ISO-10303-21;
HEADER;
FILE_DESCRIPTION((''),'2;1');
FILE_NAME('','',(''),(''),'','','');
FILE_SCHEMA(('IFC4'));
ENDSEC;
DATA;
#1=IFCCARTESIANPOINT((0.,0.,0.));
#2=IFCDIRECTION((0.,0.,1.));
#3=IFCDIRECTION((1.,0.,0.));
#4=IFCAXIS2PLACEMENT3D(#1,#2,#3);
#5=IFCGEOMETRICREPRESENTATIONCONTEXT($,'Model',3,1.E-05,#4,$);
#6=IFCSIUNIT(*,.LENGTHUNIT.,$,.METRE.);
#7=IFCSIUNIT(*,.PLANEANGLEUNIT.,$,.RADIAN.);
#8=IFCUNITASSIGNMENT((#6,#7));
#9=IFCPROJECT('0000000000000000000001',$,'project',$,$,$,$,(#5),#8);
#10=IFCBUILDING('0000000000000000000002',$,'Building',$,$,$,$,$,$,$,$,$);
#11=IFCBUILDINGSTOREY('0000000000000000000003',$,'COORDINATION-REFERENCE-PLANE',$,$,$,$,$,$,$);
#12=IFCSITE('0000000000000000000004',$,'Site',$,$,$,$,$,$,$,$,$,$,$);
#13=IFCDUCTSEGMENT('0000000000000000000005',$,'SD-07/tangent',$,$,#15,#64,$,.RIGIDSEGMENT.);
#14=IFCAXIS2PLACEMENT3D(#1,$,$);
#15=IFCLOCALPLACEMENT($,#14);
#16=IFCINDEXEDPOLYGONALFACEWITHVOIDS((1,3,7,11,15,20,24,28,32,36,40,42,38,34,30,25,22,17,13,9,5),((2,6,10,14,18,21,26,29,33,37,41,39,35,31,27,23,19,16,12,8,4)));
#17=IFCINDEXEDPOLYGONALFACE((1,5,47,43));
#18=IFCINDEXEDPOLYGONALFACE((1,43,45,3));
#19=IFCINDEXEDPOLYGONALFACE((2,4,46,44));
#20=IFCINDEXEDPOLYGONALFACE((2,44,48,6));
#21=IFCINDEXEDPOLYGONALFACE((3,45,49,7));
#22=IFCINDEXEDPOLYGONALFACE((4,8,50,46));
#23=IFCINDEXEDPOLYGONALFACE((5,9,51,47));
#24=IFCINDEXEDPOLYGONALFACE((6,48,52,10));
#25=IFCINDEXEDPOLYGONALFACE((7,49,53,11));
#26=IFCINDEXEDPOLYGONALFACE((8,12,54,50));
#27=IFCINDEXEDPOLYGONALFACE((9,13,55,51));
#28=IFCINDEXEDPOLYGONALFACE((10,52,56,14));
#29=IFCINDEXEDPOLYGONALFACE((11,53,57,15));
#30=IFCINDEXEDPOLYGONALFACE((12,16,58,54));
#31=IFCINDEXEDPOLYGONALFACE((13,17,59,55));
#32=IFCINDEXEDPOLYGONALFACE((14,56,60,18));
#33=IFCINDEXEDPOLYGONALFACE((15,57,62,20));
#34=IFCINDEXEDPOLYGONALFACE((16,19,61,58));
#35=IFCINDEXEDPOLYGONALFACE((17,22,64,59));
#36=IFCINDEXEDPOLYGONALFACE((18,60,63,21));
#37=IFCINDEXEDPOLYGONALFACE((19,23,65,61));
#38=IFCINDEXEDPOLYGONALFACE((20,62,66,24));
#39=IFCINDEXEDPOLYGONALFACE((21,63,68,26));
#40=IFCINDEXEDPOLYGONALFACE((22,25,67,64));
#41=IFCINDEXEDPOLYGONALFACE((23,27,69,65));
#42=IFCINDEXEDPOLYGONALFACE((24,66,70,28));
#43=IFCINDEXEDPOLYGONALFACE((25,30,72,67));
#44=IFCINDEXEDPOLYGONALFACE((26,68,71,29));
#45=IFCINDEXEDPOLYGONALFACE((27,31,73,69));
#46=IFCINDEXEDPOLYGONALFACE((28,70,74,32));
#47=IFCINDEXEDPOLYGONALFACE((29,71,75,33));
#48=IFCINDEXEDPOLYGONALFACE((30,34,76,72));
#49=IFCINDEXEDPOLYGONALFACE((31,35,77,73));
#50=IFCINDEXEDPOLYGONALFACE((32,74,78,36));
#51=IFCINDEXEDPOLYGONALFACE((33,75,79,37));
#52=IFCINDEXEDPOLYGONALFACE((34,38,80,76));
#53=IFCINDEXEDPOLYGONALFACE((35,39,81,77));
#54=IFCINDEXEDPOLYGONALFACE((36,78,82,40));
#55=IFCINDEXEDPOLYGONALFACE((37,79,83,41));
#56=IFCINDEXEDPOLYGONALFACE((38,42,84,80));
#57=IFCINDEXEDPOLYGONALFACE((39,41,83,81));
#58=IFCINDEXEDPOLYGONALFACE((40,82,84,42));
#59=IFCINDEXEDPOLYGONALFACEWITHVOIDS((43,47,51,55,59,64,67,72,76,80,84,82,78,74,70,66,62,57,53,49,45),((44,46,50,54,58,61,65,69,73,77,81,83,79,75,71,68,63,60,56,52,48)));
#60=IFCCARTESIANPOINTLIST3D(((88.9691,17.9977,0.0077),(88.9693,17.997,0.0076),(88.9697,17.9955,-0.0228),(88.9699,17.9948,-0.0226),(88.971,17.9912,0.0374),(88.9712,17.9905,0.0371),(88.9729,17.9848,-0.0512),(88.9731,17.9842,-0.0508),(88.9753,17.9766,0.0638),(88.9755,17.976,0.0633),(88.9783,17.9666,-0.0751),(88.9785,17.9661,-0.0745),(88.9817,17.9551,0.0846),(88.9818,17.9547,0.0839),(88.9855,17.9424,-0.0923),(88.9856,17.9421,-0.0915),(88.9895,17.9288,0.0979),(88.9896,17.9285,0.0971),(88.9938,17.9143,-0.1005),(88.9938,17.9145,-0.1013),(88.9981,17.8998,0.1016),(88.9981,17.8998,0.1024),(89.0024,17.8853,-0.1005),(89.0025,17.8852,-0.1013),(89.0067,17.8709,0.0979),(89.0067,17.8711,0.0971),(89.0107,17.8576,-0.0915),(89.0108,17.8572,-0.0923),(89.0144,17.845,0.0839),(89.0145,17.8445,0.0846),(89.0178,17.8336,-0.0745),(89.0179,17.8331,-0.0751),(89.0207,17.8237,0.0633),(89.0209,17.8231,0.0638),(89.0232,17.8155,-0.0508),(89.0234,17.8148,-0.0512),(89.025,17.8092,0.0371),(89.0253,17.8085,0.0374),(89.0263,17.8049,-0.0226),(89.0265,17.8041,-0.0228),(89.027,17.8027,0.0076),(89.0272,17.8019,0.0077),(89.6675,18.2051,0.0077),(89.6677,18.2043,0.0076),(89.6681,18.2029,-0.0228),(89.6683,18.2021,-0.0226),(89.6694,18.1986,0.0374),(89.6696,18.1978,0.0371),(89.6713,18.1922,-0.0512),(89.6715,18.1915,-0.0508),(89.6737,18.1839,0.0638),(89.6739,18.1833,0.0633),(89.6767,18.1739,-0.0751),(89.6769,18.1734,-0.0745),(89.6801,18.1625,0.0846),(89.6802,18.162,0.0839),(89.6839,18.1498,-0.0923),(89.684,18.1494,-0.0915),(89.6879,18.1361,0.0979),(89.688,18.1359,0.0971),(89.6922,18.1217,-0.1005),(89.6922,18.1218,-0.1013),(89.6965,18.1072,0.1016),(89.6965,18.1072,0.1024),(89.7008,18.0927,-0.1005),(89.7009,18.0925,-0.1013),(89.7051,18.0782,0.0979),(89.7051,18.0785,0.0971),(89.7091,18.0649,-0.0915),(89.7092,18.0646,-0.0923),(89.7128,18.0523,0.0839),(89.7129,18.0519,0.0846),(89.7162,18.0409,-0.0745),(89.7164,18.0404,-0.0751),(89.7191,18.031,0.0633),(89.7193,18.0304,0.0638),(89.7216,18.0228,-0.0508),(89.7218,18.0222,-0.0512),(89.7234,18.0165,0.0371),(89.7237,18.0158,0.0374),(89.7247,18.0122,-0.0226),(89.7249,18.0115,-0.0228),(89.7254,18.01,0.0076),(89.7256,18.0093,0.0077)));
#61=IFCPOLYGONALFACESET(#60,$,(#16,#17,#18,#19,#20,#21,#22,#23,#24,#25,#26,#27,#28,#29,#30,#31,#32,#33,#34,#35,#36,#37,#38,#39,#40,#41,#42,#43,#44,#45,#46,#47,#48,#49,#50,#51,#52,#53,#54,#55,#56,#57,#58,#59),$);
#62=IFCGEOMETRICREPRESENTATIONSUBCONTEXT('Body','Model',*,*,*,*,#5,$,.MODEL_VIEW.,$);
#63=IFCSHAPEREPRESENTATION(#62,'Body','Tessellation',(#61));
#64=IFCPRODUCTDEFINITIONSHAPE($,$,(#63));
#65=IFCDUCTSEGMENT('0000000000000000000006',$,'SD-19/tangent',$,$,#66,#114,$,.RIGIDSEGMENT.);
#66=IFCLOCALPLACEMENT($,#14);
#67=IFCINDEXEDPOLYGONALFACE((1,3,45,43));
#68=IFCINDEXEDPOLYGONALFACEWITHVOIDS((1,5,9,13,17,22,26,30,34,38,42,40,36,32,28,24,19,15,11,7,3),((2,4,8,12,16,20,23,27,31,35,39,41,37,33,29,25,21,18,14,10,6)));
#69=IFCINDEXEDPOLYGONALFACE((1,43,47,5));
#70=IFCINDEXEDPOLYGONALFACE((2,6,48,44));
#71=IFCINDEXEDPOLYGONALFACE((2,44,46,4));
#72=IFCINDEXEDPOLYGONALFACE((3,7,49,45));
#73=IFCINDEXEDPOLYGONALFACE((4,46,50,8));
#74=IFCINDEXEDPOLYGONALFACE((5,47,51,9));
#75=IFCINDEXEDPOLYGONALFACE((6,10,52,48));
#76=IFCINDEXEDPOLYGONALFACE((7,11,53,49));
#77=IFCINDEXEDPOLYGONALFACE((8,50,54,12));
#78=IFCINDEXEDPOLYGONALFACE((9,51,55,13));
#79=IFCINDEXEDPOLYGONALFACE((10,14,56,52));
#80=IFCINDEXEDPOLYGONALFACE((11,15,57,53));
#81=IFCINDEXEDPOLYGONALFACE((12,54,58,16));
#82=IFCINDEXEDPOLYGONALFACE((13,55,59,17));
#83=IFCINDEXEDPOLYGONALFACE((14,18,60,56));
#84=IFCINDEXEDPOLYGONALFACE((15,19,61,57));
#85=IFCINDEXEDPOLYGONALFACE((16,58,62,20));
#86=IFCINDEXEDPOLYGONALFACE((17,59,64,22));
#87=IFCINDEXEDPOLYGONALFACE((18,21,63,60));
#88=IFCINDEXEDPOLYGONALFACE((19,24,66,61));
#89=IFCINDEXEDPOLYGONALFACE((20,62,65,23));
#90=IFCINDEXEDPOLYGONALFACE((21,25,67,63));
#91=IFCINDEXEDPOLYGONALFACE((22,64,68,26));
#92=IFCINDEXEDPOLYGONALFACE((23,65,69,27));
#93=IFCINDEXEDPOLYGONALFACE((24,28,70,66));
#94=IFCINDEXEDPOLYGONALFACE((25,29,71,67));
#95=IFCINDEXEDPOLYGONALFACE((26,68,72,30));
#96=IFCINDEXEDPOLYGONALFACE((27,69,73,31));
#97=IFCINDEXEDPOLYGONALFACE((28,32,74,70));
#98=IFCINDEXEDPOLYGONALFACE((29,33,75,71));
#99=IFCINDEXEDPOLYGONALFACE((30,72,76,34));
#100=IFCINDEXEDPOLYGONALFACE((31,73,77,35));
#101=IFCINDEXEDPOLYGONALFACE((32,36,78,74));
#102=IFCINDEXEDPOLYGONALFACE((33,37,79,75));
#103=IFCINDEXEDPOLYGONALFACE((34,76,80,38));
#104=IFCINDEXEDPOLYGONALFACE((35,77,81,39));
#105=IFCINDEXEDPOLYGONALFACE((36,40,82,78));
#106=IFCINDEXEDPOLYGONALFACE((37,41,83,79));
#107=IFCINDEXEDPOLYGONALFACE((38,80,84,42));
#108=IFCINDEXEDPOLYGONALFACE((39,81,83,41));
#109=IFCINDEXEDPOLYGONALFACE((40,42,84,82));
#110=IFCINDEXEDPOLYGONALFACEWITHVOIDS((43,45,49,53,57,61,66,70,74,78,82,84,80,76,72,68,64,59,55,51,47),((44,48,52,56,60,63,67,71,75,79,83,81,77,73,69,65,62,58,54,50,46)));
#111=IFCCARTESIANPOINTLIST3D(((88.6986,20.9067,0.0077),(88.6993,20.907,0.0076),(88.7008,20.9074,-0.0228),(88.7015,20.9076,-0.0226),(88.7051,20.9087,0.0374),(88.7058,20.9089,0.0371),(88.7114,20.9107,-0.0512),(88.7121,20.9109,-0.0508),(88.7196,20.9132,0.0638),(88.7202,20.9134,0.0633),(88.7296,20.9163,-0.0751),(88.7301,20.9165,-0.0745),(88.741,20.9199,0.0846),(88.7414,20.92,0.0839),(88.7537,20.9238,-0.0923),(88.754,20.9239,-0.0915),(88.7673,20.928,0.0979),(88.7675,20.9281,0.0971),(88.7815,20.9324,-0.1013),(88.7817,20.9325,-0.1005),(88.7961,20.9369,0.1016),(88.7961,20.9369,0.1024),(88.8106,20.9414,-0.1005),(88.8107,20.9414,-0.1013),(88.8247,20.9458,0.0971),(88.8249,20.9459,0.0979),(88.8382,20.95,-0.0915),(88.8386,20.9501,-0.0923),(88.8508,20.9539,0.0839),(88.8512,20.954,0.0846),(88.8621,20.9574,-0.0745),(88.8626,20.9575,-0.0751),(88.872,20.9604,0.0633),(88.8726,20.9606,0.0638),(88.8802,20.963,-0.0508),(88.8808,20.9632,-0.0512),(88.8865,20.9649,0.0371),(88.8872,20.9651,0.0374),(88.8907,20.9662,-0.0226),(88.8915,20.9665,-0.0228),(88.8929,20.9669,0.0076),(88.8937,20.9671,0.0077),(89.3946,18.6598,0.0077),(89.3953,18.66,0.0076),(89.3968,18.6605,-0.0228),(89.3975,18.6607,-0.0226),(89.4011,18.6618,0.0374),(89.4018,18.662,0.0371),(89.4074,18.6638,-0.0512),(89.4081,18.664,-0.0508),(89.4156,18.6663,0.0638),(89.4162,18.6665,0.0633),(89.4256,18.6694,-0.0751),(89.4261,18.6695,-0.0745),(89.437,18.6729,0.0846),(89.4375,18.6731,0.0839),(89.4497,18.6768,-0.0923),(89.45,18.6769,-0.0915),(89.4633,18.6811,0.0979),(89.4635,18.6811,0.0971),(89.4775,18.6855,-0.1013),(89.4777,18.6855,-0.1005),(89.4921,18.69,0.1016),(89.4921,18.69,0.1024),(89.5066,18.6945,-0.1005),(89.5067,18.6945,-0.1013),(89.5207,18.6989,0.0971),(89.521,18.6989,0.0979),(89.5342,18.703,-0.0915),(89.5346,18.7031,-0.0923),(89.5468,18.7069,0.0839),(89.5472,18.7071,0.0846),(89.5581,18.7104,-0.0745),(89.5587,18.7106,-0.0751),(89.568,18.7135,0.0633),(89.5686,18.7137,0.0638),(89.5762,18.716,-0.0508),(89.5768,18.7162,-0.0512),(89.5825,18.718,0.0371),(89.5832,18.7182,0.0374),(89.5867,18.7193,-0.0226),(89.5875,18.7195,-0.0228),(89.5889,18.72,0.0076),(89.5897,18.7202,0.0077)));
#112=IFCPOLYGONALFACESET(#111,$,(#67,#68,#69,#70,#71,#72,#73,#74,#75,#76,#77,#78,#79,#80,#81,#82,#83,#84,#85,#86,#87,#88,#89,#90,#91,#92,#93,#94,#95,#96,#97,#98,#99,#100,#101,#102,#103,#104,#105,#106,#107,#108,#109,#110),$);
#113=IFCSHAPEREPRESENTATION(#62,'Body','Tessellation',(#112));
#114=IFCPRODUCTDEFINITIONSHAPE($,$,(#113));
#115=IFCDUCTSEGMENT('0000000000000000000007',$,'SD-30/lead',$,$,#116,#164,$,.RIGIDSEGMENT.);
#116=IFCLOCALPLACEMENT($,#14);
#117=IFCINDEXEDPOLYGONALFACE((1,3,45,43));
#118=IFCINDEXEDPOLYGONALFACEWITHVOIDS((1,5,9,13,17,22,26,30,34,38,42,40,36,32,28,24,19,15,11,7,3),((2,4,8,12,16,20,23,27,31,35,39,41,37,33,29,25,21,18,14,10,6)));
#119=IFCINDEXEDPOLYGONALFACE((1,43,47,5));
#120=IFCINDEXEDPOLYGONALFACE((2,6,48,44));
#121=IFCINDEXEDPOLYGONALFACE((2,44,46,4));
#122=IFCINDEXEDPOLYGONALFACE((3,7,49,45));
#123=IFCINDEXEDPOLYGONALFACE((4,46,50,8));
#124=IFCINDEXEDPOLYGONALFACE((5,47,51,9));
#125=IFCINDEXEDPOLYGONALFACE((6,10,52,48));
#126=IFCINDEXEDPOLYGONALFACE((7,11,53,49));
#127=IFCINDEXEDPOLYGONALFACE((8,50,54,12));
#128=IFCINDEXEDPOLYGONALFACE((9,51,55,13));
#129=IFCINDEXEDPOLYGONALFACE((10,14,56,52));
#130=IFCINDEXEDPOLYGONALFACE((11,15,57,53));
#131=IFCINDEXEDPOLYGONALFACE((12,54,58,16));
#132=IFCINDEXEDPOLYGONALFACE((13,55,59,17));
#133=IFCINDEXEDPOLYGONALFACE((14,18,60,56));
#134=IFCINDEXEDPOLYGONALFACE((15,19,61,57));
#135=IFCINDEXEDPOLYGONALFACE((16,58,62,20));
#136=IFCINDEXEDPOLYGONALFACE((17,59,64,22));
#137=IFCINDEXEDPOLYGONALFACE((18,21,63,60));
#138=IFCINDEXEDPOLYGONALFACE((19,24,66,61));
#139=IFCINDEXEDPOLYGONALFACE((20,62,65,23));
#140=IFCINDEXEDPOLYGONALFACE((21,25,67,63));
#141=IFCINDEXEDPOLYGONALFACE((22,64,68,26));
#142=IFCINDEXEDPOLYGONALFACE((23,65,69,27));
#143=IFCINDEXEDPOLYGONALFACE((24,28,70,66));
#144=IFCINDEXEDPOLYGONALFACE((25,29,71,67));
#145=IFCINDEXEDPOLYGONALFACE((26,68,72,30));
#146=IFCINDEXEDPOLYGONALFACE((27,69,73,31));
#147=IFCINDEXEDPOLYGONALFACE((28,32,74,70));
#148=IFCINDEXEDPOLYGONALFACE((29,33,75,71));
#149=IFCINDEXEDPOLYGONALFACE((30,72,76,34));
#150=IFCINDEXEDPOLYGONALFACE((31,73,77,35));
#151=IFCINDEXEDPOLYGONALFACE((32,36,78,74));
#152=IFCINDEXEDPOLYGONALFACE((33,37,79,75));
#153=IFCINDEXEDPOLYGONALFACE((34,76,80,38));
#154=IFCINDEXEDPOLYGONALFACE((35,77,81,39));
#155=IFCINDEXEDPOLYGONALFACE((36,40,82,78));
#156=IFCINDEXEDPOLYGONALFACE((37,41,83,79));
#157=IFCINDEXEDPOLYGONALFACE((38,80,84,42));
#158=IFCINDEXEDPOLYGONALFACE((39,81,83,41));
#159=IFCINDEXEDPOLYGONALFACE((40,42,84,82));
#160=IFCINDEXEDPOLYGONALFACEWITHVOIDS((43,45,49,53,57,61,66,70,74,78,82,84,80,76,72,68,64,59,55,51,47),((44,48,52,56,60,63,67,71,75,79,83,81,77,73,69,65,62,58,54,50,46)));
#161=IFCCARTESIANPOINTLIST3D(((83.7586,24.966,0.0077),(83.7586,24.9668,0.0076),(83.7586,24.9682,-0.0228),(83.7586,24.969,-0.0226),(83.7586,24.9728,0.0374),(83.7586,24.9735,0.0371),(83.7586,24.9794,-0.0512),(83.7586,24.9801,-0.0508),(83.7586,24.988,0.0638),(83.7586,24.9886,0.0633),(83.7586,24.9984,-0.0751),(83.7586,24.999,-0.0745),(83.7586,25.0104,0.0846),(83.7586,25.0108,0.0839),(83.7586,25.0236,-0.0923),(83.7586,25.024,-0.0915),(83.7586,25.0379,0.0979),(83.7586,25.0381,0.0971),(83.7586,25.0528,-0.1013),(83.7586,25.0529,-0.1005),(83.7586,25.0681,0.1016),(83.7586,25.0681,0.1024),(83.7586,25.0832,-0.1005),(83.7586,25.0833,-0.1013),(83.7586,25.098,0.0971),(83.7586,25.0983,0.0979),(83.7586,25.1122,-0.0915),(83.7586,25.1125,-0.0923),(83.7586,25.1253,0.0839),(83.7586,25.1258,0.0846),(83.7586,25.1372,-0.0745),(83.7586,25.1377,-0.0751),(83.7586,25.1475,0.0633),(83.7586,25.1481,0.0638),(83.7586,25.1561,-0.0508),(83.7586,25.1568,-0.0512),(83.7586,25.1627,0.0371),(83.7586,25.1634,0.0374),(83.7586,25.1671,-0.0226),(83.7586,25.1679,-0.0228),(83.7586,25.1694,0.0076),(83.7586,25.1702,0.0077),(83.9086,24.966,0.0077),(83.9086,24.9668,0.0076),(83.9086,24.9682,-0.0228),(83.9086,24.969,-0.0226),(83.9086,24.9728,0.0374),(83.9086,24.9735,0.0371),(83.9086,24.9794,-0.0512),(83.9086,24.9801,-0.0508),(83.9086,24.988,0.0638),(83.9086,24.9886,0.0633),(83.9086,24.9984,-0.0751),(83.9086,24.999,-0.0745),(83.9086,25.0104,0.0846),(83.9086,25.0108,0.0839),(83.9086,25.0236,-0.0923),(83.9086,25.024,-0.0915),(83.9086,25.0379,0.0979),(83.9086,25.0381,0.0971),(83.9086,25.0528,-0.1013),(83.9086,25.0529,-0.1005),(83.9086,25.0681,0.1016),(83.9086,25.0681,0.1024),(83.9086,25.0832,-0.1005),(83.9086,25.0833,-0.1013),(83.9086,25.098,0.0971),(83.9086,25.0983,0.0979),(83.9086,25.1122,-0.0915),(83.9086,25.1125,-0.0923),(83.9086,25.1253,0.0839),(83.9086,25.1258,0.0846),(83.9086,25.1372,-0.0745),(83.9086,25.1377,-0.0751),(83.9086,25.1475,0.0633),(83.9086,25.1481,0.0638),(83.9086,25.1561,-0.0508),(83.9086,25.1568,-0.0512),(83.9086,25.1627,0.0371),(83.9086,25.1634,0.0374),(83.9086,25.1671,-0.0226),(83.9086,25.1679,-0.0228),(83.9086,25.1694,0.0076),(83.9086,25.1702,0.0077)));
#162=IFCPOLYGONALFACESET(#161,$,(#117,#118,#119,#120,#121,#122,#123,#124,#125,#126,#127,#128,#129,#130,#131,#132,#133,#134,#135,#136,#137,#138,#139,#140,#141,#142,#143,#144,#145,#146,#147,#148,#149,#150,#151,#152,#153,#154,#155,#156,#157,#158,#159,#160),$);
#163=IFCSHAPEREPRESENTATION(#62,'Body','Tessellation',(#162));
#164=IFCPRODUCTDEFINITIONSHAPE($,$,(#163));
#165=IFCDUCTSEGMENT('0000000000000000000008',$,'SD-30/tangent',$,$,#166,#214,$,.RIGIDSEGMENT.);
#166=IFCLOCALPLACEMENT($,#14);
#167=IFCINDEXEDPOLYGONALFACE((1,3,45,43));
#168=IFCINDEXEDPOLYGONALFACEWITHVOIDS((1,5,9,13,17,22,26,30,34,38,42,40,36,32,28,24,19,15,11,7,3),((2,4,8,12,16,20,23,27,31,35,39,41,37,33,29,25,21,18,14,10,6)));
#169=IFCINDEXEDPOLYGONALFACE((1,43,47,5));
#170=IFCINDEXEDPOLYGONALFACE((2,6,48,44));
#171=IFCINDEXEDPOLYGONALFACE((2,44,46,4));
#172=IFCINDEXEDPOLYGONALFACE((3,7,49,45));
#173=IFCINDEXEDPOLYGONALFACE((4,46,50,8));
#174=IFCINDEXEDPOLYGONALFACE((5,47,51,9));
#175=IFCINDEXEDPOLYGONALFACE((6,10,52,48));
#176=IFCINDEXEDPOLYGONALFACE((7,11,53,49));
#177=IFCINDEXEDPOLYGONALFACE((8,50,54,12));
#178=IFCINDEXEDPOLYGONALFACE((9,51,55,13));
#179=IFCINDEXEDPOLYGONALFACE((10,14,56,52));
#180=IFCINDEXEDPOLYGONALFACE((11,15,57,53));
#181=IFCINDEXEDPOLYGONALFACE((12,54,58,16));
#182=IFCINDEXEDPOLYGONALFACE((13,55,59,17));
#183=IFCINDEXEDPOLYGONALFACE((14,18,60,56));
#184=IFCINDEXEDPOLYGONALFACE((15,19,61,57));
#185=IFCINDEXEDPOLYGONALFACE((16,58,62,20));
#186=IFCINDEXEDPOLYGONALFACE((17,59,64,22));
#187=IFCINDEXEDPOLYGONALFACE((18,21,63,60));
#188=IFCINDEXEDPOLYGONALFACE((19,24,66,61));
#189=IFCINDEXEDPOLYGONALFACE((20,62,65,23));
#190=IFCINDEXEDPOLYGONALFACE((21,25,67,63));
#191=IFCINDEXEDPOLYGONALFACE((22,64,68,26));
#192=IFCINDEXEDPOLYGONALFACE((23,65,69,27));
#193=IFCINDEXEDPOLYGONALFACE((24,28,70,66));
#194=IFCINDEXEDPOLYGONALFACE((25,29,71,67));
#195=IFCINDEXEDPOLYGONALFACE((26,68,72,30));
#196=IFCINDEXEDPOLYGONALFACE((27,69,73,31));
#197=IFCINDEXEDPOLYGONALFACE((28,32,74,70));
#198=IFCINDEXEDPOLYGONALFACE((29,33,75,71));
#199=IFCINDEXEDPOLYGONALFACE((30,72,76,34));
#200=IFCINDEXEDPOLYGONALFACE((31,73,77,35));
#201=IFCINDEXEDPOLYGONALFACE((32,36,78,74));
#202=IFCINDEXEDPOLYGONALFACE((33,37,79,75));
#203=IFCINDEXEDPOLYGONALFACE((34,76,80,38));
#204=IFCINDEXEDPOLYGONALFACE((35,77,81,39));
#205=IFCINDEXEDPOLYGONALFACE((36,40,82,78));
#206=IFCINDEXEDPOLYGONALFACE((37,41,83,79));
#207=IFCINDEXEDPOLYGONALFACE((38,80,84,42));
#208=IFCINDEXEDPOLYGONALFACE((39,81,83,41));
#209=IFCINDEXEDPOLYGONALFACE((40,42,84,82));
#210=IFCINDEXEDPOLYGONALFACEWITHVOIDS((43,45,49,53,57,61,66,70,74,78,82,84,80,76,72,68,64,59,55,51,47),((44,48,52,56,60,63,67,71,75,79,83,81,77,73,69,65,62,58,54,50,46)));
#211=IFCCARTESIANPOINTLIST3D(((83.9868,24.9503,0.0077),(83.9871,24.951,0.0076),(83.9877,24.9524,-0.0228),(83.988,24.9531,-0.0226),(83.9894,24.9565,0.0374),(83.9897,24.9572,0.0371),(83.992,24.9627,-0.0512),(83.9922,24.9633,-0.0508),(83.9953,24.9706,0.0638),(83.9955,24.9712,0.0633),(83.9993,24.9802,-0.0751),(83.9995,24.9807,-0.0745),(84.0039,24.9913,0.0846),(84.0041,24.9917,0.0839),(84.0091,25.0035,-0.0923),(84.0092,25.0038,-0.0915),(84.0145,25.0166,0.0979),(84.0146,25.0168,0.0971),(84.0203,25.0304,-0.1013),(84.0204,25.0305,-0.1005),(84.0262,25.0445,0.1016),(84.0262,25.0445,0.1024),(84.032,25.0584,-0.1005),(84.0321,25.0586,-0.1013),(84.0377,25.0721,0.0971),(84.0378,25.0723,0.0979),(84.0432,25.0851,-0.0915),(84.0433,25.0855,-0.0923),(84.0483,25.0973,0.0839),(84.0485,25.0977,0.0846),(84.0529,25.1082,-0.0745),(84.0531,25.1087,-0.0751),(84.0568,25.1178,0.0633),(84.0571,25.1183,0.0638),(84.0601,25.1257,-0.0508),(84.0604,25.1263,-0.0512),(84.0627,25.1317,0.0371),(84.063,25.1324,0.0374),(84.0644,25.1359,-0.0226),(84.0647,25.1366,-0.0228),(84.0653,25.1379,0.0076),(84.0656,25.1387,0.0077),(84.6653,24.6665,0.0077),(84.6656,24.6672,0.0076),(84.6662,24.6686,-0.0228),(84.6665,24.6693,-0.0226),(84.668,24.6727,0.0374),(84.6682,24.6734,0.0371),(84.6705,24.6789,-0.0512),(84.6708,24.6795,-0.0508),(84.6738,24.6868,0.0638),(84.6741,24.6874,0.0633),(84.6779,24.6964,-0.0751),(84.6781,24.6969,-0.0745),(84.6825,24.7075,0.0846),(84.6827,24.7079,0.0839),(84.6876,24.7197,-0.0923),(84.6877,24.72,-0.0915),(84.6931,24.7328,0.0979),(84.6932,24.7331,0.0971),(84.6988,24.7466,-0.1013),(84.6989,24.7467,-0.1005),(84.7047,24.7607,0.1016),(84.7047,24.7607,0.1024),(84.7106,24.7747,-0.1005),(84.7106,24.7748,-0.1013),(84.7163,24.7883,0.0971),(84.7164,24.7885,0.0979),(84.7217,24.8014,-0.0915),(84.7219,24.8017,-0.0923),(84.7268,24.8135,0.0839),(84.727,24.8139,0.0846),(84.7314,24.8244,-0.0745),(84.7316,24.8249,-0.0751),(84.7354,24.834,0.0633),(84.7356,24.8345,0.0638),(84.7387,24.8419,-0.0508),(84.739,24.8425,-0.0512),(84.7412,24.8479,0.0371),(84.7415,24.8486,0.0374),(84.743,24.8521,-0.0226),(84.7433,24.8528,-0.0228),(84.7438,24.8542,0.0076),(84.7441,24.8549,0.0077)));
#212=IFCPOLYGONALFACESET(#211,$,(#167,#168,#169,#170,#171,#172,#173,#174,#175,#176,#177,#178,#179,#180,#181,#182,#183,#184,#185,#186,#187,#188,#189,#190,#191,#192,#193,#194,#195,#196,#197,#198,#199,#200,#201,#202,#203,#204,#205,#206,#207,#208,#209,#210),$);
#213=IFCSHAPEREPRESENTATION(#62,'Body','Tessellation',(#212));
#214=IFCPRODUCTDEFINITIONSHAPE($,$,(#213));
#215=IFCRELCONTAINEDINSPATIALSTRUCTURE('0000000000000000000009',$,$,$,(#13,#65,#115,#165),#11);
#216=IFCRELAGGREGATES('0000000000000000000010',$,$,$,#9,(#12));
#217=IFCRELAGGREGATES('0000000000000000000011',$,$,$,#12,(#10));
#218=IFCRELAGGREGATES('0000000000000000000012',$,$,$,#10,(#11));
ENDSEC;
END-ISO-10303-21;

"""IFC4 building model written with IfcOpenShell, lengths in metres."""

from ifc_helpers import new_model, si_unit, frame, origin_with_axes, place, context, subcontext, project, spatial, hollow_circle, extrude, element, save


model = new_model("IFC4")

# Units and contexts
model_context = context("Model", 3, precision=1e-05, world=origin_with_axes())
body_context_1 = subcontext(model_context, "Body", "Model", "MODEL_VIEW")
ifc_project = project(units=[si_unit("LENGTHUNIT", "METRE"), si_unit("PLANEANGLEUNIT", "RADIAN")], contexts=[model_context])

# Site, building, storey
site = spatial("IfcSite", under=ifc_project, Name="Site")
building = spatial("IfcBuilding", under=site, Name="Building")
storey = spatial("IfcBuildingStorey", under=building, Name="COORDINATION-REFERENCE-PLANE")

# Duct segment
duct_segment_1_placement = place(None, frame((89.6965, 18.1072, 0.0), z_axis=(-0.958645, -0.284603, 0.0), x_axis=(0.0, 0.0, 1.0)))
element("IfcDuctSegment", 1, at=duct_segment_1_placement, inside=storey, Name="SD-07/tangent", PredefinedType="RIGIDSEGMENT", context=body_context_1, shape_type="SweptSolid", body=[
    extrude(hollow_circle(Radius=0.1024, WallThickness=0.0008), origin_with_axes(), (0.0, 0.0, 1.0), 0.7285),
])

# Duct segment
duct_segment_2_placement = place(None, frame((89.4921, 18.69, 0.0), z_axis=(-0.295887, 0.955223, 0.0), x_axis=(0.0, 0.0, 1.0)))
element("IfcDuctSegment", 2, at=duct_segment_2_placement, inside=storey, Name="SD-19/tangent", PredefinedType="RIGIDSEGMENT", context=body_context_1, shape_type="SweptSolid", body=[
    extrude(hollow_circle(Radius=0.1024, WallThickness=0.0008), origin_with_axes(), (0.0, 0.0, 1.0), 2.3523),
])

# Duct segment
duct_segment_3_placement = place(None, frame((83.7586, 25.0681, 0.0), z_axis=(1.0, 0.0, 0.0), x_axis=(0.0, 0.0, 1.0)))
element("IfcDuctSegment", 3, at=duct_segment_3_placement, inside=storey, Name="SD-30/lead", PredefinedType="RIGIDSEGMENT", context=body_context_1, shape_type="SweptSolid", body=[
    extrude(hollow_circle(Radius=0.1024, WallThickness=0.0008), origin_with_axes(), (0.0, 0.0, 1.0), 0.15),
])

# Duct segment
duct_segment_4_placement = place(None, frame((84.0262, 25.0445, 0.0), z_axis=(0.922564, -0.385845, 0.0), x_axis=(0.0, 0.0, 1.0)))
element("IfcDuctSegment", 4, at=duct_segment_4_placement, inside=storey, Name="SD-30/tangent", PredefinedType="RIGIDSEGMENT", context=body_context_1, shape_type="SweptSolid", body=[
    extrude(hollow_circle(Radius=0.1024, WallThickness=0.0008), origin_with_axes(), (0.0, 0.0, 1.0), 0.7355),
])

save(model, "model.ifc")
